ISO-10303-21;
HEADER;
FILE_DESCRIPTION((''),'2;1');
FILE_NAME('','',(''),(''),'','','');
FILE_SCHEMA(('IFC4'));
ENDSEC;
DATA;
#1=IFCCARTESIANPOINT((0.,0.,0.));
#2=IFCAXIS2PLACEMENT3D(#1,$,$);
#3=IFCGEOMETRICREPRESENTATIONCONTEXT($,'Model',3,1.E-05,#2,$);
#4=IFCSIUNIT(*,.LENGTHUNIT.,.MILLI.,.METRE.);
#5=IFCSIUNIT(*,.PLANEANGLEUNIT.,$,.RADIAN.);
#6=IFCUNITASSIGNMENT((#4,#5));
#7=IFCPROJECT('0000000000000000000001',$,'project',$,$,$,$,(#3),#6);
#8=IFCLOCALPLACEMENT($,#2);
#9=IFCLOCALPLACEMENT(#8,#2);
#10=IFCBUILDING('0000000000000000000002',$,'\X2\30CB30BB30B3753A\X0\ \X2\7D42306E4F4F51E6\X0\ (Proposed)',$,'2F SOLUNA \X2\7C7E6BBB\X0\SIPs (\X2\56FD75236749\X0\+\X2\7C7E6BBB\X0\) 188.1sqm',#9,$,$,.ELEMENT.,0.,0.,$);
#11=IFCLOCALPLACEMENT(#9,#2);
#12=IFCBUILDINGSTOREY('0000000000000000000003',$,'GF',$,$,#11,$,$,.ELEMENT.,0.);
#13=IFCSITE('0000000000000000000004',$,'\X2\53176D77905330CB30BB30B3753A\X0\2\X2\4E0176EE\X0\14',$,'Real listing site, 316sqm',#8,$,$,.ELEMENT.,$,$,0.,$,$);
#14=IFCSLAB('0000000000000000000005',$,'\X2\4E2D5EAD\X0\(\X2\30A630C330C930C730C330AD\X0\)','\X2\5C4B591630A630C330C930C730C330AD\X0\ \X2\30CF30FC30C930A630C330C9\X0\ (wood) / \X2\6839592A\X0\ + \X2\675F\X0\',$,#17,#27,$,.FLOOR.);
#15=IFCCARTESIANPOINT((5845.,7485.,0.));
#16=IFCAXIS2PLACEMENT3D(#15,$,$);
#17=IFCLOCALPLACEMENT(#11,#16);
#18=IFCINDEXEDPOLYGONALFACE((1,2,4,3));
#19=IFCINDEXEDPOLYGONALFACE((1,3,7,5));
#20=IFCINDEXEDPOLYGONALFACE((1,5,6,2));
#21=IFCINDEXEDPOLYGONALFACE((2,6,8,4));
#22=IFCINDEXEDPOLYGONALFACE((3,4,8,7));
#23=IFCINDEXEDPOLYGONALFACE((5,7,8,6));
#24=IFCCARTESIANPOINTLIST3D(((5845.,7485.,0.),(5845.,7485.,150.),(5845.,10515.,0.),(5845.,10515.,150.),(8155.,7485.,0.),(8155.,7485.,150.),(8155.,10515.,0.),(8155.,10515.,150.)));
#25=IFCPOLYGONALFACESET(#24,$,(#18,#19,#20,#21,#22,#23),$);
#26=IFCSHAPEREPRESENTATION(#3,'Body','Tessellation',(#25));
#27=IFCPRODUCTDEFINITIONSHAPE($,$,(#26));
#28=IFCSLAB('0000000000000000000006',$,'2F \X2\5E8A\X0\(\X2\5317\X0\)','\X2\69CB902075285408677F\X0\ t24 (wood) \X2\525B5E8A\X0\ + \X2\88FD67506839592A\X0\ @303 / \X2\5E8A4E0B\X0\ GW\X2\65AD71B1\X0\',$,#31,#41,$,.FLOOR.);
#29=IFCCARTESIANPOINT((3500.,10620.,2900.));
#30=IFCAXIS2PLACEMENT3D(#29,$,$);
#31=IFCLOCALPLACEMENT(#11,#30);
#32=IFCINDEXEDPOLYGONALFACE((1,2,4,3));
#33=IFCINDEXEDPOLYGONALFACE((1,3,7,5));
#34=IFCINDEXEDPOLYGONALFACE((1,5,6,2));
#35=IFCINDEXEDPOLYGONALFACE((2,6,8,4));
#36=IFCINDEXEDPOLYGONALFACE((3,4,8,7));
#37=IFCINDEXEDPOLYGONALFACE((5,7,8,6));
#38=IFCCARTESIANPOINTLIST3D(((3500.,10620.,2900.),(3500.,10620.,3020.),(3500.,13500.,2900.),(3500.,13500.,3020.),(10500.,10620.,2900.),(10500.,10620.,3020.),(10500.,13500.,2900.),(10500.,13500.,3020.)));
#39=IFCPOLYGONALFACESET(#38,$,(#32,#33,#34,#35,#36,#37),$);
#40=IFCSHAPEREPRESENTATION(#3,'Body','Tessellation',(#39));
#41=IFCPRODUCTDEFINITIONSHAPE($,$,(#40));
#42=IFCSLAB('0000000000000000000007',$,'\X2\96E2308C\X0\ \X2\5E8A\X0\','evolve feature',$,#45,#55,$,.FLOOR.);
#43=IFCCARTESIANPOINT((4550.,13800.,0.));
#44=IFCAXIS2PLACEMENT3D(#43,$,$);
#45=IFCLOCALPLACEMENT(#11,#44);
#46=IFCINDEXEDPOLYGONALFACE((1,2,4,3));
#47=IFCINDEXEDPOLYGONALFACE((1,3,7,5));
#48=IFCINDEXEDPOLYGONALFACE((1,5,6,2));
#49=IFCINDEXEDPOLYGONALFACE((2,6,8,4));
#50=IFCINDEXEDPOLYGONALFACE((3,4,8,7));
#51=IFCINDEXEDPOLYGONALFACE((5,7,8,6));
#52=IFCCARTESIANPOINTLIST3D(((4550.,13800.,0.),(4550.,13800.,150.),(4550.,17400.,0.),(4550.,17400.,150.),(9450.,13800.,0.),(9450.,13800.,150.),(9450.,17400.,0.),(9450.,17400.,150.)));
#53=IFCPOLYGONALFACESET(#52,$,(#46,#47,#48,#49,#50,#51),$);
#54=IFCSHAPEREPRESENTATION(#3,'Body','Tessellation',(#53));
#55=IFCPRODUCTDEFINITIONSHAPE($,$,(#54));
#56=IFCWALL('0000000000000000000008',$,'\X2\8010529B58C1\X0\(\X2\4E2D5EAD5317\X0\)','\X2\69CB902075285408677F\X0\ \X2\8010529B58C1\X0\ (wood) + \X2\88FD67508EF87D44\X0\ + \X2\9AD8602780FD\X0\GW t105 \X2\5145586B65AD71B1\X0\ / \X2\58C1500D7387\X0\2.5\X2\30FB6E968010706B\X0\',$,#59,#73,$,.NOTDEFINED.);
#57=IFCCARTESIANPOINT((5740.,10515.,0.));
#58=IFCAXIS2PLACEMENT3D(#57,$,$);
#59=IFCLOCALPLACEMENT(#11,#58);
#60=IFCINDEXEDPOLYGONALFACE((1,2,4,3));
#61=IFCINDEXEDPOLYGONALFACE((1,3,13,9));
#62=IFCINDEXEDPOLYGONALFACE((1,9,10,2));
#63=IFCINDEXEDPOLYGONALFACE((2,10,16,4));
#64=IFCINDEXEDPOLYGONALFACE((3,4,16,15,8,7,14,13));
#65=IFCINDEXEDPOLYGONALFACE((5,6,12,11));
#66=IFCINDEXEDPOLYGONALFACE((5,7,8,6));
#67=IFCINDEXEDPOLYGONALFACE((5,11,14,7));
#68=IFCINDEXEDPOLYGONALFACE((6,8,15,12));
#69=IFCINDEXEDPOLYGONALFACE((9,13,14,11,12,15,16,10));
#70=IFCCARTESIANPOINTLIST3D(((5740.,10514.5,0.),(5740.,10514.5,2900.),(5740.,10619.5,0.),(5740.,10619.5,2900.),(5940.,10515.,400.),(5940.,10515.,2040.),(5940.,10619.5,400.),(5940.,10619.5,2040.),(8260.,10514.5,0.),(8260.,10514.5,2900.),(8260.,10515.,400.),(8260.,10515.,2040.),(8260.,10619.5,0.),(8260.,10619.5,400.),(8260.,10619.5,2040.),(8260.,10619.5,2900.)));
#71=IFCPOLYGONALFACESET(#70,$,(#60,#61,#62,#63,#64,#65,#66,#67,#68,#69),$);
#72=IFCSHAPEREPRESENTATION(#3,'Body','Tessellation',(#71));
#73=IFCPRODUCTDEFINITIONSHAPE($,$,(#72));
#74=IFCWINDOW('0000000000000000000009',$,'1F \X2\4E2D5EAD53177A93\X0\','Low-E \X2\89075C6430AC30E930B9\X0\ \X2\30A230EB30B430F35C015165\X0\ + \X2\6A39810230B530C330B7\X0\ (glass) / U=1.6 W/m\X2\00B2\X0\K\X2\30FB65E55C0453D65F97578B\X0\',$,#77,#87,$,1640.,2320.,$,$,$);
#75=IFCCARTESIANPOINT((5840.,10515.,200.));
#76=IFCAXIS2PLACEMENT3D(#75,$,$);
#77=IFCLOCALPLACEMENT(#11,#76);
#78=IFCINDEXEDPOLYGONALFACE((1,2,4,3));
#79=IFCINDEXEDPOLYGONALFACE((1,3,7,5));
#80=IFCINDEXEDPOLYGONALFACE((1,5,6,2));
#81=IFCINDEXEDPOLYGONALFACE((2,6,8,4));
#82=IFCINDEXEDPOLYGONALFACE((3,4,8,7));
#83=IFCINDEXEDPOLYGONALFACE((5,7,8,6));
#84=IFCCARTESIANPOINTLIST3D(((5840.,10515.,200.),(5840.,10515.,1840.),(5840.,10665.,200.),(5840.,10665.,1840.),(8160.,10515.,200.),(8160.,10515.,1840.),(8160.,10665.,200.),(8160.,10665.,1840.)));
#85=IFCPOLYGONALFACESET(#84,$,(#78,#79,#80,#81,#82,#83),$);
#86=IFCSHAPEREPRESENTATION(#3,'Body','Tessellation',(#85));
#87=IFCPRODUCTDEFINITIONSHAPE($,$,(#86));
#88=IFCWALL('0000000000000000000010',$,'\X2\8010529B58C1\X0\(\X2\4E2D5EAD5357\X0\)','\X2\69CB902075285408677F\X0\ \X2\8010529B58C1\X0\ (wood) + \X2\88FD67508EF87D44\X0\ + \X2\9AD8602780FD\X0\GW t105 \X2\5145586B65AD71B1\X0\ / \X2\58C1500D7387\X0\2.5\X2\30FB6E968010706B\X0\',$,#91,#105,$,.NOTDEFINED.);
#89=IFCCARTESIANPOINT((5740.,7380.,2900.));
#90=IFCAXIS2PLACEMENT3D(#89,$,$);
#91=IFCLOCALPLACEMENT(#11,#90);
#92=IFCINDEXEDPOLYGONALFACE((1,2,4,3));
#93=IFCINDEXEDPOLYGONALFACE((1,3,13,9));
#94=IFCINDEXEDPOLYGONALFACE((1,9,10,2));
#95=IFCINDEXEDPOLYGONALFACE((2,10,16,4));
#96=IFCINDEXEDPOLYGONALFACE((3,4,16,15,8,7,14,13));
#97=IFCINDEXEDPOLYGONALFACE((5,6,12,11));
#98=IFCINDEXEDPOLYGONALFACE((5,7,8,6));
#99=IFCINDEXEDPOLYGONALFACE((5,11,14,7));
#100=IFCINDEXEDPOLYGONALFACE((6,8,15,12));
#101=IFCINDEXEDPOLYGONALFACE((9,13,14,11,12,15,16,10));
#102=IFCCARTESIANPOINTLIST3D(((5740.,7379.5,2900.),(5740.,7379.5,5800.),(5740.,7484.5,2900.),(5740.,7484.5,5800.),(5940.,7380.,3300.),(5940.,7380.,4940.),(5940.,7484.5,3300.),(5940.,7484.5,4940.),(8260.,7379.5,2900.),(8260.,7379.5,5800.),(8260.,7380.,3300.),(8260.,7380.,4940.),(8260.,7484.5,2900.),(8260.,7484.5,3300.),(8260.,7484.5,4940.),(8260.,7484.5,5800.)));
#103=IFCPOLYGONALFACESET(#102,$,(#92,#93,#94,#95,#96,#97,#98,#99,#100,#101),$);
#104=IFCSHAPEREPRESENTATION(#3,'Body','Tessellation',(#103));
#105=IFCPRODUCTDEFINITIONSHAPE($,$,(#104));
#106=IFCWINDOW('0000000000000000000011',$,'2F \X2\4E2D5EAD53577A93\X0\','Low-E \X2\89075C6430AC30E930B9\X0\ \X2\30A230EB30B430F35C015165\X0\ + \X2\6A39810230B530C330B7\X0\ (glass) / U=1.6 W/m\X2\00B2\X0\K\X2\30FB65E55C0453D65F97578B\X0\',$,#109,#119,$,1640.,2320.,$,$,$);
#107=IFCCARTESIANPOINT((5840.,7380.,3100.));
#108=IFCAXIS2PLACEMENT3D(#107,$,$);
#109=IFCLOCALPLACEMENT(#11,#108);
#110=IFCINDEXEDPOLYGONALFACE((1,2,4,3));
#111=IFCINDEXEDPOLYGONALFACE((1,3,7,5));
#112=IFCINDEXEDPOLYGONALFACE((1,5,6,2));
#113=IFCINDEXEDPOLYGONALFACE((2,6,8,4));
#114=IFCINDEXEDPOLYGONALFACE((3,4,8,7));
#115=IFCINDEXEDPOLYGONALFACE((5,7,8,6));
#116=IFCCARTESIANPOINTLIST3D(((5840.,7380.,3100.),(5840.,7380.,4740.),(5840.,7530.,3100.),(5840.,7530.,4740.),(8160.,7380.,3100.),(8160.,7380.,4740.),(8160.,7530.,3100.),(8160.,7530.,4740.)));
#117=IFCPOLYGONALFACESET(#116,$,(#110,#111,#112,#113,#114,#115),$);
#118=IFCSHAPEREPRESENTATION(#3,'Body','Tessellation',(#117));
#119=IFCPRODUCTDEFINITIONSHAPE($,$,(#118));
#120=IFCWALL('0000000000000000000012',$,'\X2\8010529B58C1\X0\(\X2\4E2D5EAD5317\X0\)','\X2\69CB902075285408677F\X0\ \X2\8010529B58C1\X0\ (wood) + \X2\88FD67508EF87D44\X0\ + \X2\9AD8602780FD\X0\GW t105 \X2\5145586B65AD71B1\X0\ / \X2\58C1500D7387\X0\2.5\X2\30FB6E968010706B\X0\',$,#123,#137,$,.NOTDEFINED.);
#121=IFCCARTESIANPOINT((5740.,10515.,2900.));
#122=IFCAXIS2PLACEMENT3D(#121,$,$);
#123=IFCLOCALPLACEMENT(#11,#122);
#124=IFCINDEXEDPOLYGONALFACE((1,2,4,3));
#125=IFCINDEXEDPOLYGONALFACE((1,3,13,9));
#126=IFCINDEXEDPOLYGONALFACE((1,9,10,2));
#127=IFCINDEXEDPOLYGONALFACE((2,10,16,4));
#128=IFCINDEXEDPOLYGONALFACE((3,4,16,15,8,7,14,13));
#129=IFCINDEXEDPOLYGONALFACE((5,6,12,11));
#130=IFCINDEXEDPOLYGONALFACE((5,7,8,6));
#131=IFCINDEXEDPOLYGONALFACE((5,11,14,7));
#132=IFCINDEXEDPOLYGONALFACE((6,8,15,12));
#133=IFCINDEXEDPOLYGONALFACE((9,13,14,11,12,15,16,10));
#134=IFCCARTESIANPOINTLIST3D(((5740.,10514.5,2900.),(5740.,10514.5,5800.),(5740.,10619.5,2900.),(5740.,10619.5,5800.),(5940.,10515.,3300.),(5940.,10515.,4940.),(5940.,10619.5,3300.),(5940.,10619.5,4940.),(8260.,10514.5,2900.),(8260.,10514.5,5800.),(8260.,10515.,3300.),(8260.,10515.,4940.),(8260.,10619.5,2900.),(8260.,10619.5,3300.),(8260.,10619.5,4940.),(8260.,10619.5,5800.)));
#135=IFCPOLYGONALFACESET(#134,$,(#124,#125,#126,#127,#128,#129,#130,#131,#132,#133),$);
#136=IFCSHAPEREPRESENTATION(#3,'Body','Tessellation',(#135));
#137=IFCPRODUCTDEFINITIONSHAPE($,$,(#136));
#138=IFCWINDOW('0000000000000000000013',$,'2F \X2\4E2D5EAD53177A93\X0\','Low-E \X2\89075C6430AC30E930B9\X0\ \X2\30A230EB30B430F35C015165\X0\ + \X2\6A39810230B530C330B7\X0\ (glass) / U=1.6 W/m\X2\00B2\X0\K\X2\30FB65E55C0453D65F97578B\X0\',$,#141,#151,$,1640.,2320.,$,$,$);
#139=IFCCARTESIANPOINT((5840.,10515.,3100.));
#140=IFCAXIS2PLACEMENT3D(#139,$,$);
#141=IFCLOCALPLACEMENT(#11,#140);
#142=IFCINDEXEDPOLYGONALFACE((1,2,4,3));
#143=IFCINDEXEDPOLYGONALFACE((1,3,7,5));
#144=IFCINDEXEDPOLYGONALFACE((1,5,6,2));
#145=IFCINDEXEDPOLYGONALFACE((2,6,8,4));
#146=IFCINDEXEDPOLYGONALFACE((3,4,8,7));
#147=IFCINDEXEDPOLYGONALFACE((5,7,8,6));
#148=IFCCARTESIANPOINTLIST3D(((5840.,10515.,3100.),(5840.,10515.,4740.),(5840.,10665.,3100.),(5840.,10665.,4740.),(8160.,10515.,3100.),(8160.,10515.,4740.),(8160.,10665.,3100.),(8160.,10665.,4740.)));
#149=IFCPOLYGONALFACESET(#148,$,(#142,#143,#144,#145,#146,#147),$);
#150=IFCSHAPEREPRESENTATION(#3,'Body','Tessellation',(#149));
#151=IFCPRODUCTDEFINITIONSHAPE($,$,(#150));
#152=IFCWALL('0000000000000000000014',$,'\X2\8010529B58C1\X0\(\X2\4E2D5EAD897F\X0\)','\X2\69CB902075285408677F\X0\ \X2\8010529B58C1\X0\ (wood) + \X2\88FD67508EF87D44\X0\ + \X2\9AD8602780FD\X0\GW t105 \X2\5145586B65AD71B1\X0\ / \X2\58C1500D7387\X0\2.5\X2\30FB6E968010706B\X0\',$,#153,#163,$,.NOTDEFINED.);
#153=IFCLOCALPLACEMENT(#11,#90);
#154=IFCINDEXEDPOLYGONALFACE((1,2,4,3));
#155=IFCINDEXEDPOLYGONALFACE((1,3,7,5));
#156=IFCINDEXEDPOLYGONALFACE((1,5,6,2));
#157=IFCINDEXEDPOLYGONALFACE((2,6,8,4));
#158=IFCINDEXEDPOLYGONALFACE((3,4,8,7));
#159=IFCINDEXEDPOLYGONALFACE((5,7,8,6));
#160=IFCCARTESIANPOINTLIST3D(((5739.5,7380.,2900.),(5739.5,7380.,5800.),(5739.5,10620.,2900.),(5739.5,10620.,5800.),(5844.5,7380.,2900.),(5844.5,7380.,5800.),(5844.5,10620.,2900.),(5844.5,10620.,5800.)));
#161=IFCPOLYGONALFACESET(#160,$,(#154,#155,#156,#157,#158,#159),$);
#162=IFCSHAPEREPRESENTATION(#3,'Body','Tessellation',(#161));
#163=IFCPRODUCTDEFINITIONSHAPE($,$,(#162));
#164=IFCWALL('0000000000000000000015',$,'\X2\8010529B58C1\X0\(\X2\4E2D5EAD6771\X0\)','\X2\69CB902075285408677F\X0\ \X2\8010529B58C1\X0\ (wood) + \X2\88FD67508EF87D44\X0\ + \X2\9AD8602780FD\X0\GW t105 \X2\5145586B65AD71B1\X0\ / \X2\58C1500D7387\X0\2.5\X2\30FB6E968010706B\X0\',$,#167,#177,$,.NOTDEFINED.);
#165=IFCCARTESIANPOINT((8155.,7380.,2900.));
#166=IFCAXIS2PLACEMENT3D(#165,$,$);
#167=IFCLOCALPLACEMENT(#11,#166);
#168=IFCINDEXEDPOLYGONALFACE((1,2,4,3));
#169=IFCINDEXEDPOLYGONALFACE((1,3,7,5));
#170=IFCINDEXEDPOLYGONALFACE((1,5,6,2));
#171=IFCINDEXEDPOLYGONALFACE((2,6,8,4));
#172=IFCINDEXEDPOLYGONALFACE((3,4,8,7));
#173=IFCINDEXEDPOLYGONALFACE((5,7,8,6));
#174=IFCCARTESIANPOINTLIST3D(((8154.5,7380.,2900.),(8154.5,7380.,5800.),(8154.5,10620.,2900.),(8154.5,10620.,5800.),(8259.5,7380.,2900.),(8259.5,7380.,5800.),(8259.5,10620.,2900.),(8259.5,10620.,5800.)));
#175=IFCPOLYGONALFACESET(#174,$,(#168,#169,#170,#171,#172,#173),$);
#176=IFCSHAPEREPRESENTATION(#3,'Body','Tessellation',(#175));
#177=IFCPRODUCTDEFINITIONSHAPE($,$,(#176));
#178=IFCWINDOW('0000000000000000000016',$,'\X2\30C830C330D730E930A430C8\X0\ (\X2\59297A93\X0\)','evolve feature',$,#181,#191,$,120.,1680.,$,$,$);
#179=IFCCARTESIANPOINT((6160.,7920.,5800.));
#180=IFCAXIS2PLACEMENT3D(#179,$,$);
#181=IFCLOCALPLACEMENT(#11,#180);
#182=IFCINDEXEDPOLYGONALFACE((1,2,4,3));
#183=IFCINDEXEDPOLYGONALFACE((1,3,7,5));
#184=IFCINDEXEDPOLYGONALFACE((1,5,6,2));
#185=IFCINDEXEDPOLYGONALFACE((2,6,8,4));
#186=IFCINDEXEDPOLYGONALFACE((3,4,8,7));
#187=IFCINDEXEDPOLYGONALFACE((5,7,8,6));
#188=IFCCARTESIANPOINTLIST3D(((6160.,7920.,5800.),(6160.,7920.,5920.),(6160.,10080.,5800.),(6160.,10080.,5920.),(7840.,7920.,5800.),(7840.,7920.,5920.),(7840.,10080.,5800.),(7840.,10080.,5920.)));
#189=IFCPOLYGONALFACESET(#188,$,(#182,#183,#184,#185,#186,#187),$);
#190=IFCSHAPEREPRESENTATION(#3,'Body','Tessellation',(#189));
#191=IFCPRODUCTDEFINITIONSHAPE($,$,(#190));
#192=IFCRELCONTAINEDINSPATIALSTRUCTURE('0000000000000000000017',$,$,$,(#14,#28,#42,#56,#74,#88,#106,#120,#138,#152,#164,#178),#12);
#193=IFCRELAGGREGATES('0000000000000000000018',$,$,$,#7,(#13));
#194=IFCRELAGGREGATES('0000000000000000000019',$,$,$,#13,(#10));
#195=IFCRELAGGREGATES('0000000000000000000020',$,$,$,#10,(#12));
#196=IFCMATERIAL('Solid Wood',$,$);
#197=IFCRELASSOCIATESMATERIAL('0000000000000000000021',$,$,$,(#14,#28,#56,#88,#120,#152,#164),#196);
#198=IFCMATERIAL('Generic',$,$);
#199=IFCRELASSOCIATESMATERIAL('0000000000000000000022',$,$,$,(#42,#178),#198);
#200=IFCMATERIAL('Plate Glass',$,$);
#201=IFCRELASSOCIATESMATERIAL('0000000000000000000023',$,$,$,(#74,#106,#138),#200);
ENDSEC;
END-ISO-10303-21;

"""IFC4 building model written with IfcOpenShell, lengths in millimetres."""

from ifc_helpers import new_model, si_unit, frame, frame_2d, origin, place, context, project, spatial, rectangle, extrude, material, element, fill, save


model = new_model("IFC4")

# Units and contexts
model_context = context("Model", 3, precision=1e-05, world=origin())
ifc_project = project(units=[si_unit("LENGTHUNIT", "METRE", prefix="MILLI"), si_unit("PLANEANGLEUNIT", "RADIAN")], contexts=[model_context])

# Site, building, storey
site_placement = place(None, origin())
site = spatial("IfcSite", under=ifc_project, at=site_placement, Name="北海道ニセコ町2丁目14", ObjectType="Real listing site, 316sqm", CompositionType="ELEMENT", RefElevation=0.0)
building_placement = place(site_placement, origin())
building = spatial("IfcBuilding", under=site, at=building_placement, Name="ニセコ町 終の住処 (Proposed)", ObjectType="2F SOLUNA 籾殻SIPs (国産杉+籾殻) 188.1sqm", CompositionType="ELEMENT", ElevationOfRefHeight=0.0, ElevationOfTerrain=0.0)
storey_placement = place(building_placement, origin())
storey = spatial("IfcBuildingStorey", under=building, at=storey_placement, Name="GF", CompositionType="ELEMENT", Elevation=0.0)

# Slabs
ifc_material_1 = material(Name="Solid Wood")
slab_1_placement = place(storey_placement, frame((5845.0, 7485.0, 0.0)))
element("IfcSlab", 1, at=slab_1_placement, inside=storey, material=ifc_material_1, Name="中庭(ウッドデッキ)", Description="屋外ウッドデッキ ハードウッド (wood) / 根太 + 束", PredefinedType="FLOOR", context=model_context, shape_type="SweptSolid", body=[
    extrude(rectangle(XDim=2310.0, YDim=3030.0, at=frame_2d((1155.0, 1515.0))), frame((5845.0, 7485.0, 0.0)), (0.0, 0.0, 1.0), 150.0),
])
slab_2_placement = place(storey_placement, frame((3500.0, 10620.0, 2900.0)))
element("IfcSlab", 2, at=slab_2_placement, inside=storey, material=ifc_material_1, Name="2F 床(北)", Description="構造用合板 t24 (wood) 剛床 + 製材根太 @303 / 床下 GW断熱", PredefinedType="FLOOR", context=model_context, shape_type="SweptSolid", body=[
    extrude(rectangle(XDim=7000.0, YDim=2880.0, at=frame_2d((3500.0, 1440.0))), frame((3500.0, 10620.0, 2900.0)), (0.0, 0.0, 1.0), 120.0),
])
ifc_material_2 = material(Name="Generic")
slab_3_placement = place(storey_placement, frame((4550.0, 13800.0, 0.0)))
element("IfcSlab", 3, at=slab_3_placement, inside=storey, material=ifc_material_2, Name="離れ 床", Description="evolve feature", PredefinedType="FLOOR", context=model_context, shape_type="SweptSolid", body=[
    extrude(rectangle(XDim=4900.0, YDim=3600.0, at=frame_2d((2450.0, 1800.0))), frame((4550.0, 13800.0, 0.0)), (0.0, 0.0, 1.0), 150.0),
])

# Wall, opening, window
wall_1_placement = place(storey_placement, frame((5740.0, 10515.0, 0.0)))
wall_1 = element("IfcWall", 4, at=wall_1_placement, inside=storey, material=ifc_material_1, Name="耐力壁(中庭北)", Description="構造用合板 耐力壁 (wood) + 製材軸組 + 高性能GW t105 充填断熱 / 壁倍率2.5・準耐火", PredefinedType="NOTDEFINED", context=model_context, shape_type="SweptSolid", body=[
    extrude(rectangle(XDim=2520.0, YDim=105.0, at=frame_2d((1260.0, 52.0))), frame((5740.0, 10515.0, 0.0)), (0.0, 0.0, 1.0), 2900.0),
])
opening_1_placement = place(storey_placement, frame((5840.0, 10515.0, 200.0)))
opening_1 = element("IfcOpeningElement", 5, at=opening_1_placement, cuts=wall_1, PredefinedType="NOTDEFINED", context=model_context, shape_type="SweptSolid", body=[
    extrude(rectangle(XDim=2320.0, YDim=150.0, at=frame_2d((1160.0, 75.0))), frame((5840.0, 10515.0, 200.0)), (0.0, 0.0, 1.0), 1640.0),
])
ifc_material_3 = material(Name="Plate Glass")
window_1_placement = place(storey_placement, frame((5840.0, 10515.0, 200.0)))
window_1 = element("IfcWindow", 6, at=window_1_placement, inside=storey, material=ifc_material_3, Name="1F 中庭北窓", Description="Low-E 複層ガラス アルゴン封入 + 樹脂サッシ (glass) / U=1.6 W/m²K・日射取得型", OverallHeight=1640.0, OverallWidth=2320.0, context=model_context, shape_type="SweptSolid", body=[
    extrude(rectangle(XDim=2320.0, YDim=150.0, at=frame_2d((1160.0, 75.0))), frame((5840.0, 10515.0, 200.0)), (0.0, 0.0, 1.0), 1640.0),
])
fill(opening_1, window_1)

# Walls, openings, windows
wall_2_placement = place(storey_placement, frame((5740.0, 7380.0, 2900.0)))
wall_2 = element("IfcWall", 7, at=wall_2_placement, inside=storey, material=ifc_material_1, Name="耐力壁(中庭南)", Description="構造用合板 耐力壁 (wood) + 製材軸組 + 高性能GW t105 充填断熱 / 壁倍率2.5・準耐火", PredefinedType="NOTDEFINED", context=model_context, shape_type="SweptSolid", body=[
    extrude(rectangle(XDim=2520.0, YDim=105.0, at=frame_2d((1260.0, 52.0))), frame((5740.0, 7380.0, 2900.0)), (0.0, 0.0, 1.0), 2900.0),
])
opening_2_placement = place(storey_placement, frame((5840.0, 7380.0, 3100.0)))
opening_2 = element("IfcOpeningElement", 8, at=opening_2_placement, cuts=wall_2, PredefinedType="NOTDEFINED", context=model_context, shape_type="SweptSolid", body=[
    extrude(rectangle(XDim=2320.0, YDim=150.0, at=frame_2d((1160.0, 75.0))), frame((5840.0, 7380.0, 3100.0)), (0.0, 0.0, 1.0), 1640.0),
])
window_2_placement = place(storey_placement, frame((5840.0, 7380.0, 3100.0)))
window_2 = element("IfcWindow", 9, at=window_2_placement, inside=storey, material=ifc_material_3, Name="2F 中庭南窓", Description="Low-E 複層ガラス アルゴン封入 + 樹脂サッシ (glass) / U=1.6 W/m²K・日射取得型", OverallHeight=1640.0, OverallWidth=2320.0, context=model_context, shape_type="SweptSolid", body=[
    extrude(rectangle(XDim=2320.0, YDim=150.0, at=frame_2d((1160.0, 75.0))), frame((5840.0, 7380.0, 3100.0)), (0.0, 0.0, 1.0), 1640.0),
])
fill(opening_2, window_2)
wall_3_placement = place(storey_placement, frame((5740.0, 10515.0, 2900.0)))
wall_3 = element("IfcWall", 10, at=wall_3_placement, inside=storey, material=ifc_material_1, Name="耐力壁(中庭北)", Description="構造用合板 耐力壁 (wood) + 製材軸組 + 高性能GW t105 充填断熱 / 壁倍率2.5・準耐火", PredefinedType="NOTDEFINED", context=model_context, shape_type="SweptSolid", body=[
    extrude(rectangle(XDim=2520.0, YDim=105.0, at=frame_2d((1260.0, 52.0))), frame((5740.0, 10515.0, 2900.0)), (0.0, 0.0, 1.0), 2900.0),
])
opening_3_placement = place(storey_placement, frame((5840.0, 10515.0, 3100.0)))
opening_3 = element("IfcOpeningElement", 11, at=opening_3_placement, cuts=wall_3, PredefinedType="NOTDEFINED", context=model_context, shape_type="SweptSolid", body=[
    extrude(rectangle(XDim=2320.0, YDim=150.0, at=frame_2d((1160.0, 75.0))), frame((5840.0, 10515.0, 3100.0)), (0.0, 0.0, 1.0), 1640.0),
])
window_3_placement = place(storey_placement, frame((5840.0, 10515.0, 3100.0)))
window_3 = element("IfcWindow", 12, at=window_3_placement, inside=storey, material=ifc_material_3, Name="2F 中庭北窓", Description="Low-E 複層ガラス アルゴン封入 + 樹脂サッシ (glass) / U=1.6 W/m²K・日射取得型", OverallHeight=1640.0, OverallWidth=2320.0, context=model_context, shape_type="SweptSolid", body=[
    extrude(rectangle(XDim=2320.0, YDim=150.0, at=frame_2d((1160.0, 75.0))), frame((5840.0, 10515.0, 3100.0)), (0.0, 0.0, 1.0), 1640.0),
])
fill(opening_3, window_3)

# Walls
wall_4_placement = place(storey_placement, frame((5740.0, 7380.0, 2900.0)))
element("IfcWall", 13, at=wall_4_placement, inside=storey, material=ifc_material_1, Name="耐力壁(中庭西)", Description="構造用合板 耐力壁 (wood) + 製材軸組 + 高性能GW t105 充填断熱 / 壁倍率2.5・準耐火", PredefinedType="NOTDEFINED", context=model_context, shape_type="SweptSolid", body=[
    extrude(rectangle(XDim=105.0, YDim=3240.0, at=frame_2d((52.0, 1620.0))), frame((5740.0, 7380.0, 2900.0)), (0.0, 0.0, 1.0), 2900.0),
])
wall_5_placement = place(storey_placement, frame((8155.0, 7380.0, 2900.0)))
element("IfcWall", 14, at=wall_5_placement, inside=storey, material=ifc_material_1, Name="耐力壁(中庭東)", Description="構造用合板 耐力壁 (wood) + 製材軸組 + 高性能GW t105 充填断熱 / 壁倍率2.5・準耐火", PredefinedType="NOTDEFINED", context=model_context, shape_type="SweptSolid", body=[
    extrude(rectangle(XDim=105.0, YDim=3240.0, at=frame_2d((52.0, 1620.0))), frame((8155.0, 7380.0, 2900.0)), (0.0, 0.0, 1.0), 2900.0),
])

# Window
window_4_placement = place(storey_placement, frame((6160.0, 7920.0, 5800.0)))
element("IfcWindow", 15, at=window_4_placement, inside=storey, material=ifc_material_2, Name="トップライト (天窓)", Description="evolve feature", OverallHeight=120.0, OverallWidth=1680.0, context=model_context, shape_type="SweptSolid", body=[
    extrude(rectangle(XDim=1680.0, YDim=2160.0, at=frame_2d((840.0, 1080.0))), frame((6160.0, 7920.0, 5800.0)), (0.0, 0.0, 1.0), 120.0),
])

save(model, "model.ifc")
